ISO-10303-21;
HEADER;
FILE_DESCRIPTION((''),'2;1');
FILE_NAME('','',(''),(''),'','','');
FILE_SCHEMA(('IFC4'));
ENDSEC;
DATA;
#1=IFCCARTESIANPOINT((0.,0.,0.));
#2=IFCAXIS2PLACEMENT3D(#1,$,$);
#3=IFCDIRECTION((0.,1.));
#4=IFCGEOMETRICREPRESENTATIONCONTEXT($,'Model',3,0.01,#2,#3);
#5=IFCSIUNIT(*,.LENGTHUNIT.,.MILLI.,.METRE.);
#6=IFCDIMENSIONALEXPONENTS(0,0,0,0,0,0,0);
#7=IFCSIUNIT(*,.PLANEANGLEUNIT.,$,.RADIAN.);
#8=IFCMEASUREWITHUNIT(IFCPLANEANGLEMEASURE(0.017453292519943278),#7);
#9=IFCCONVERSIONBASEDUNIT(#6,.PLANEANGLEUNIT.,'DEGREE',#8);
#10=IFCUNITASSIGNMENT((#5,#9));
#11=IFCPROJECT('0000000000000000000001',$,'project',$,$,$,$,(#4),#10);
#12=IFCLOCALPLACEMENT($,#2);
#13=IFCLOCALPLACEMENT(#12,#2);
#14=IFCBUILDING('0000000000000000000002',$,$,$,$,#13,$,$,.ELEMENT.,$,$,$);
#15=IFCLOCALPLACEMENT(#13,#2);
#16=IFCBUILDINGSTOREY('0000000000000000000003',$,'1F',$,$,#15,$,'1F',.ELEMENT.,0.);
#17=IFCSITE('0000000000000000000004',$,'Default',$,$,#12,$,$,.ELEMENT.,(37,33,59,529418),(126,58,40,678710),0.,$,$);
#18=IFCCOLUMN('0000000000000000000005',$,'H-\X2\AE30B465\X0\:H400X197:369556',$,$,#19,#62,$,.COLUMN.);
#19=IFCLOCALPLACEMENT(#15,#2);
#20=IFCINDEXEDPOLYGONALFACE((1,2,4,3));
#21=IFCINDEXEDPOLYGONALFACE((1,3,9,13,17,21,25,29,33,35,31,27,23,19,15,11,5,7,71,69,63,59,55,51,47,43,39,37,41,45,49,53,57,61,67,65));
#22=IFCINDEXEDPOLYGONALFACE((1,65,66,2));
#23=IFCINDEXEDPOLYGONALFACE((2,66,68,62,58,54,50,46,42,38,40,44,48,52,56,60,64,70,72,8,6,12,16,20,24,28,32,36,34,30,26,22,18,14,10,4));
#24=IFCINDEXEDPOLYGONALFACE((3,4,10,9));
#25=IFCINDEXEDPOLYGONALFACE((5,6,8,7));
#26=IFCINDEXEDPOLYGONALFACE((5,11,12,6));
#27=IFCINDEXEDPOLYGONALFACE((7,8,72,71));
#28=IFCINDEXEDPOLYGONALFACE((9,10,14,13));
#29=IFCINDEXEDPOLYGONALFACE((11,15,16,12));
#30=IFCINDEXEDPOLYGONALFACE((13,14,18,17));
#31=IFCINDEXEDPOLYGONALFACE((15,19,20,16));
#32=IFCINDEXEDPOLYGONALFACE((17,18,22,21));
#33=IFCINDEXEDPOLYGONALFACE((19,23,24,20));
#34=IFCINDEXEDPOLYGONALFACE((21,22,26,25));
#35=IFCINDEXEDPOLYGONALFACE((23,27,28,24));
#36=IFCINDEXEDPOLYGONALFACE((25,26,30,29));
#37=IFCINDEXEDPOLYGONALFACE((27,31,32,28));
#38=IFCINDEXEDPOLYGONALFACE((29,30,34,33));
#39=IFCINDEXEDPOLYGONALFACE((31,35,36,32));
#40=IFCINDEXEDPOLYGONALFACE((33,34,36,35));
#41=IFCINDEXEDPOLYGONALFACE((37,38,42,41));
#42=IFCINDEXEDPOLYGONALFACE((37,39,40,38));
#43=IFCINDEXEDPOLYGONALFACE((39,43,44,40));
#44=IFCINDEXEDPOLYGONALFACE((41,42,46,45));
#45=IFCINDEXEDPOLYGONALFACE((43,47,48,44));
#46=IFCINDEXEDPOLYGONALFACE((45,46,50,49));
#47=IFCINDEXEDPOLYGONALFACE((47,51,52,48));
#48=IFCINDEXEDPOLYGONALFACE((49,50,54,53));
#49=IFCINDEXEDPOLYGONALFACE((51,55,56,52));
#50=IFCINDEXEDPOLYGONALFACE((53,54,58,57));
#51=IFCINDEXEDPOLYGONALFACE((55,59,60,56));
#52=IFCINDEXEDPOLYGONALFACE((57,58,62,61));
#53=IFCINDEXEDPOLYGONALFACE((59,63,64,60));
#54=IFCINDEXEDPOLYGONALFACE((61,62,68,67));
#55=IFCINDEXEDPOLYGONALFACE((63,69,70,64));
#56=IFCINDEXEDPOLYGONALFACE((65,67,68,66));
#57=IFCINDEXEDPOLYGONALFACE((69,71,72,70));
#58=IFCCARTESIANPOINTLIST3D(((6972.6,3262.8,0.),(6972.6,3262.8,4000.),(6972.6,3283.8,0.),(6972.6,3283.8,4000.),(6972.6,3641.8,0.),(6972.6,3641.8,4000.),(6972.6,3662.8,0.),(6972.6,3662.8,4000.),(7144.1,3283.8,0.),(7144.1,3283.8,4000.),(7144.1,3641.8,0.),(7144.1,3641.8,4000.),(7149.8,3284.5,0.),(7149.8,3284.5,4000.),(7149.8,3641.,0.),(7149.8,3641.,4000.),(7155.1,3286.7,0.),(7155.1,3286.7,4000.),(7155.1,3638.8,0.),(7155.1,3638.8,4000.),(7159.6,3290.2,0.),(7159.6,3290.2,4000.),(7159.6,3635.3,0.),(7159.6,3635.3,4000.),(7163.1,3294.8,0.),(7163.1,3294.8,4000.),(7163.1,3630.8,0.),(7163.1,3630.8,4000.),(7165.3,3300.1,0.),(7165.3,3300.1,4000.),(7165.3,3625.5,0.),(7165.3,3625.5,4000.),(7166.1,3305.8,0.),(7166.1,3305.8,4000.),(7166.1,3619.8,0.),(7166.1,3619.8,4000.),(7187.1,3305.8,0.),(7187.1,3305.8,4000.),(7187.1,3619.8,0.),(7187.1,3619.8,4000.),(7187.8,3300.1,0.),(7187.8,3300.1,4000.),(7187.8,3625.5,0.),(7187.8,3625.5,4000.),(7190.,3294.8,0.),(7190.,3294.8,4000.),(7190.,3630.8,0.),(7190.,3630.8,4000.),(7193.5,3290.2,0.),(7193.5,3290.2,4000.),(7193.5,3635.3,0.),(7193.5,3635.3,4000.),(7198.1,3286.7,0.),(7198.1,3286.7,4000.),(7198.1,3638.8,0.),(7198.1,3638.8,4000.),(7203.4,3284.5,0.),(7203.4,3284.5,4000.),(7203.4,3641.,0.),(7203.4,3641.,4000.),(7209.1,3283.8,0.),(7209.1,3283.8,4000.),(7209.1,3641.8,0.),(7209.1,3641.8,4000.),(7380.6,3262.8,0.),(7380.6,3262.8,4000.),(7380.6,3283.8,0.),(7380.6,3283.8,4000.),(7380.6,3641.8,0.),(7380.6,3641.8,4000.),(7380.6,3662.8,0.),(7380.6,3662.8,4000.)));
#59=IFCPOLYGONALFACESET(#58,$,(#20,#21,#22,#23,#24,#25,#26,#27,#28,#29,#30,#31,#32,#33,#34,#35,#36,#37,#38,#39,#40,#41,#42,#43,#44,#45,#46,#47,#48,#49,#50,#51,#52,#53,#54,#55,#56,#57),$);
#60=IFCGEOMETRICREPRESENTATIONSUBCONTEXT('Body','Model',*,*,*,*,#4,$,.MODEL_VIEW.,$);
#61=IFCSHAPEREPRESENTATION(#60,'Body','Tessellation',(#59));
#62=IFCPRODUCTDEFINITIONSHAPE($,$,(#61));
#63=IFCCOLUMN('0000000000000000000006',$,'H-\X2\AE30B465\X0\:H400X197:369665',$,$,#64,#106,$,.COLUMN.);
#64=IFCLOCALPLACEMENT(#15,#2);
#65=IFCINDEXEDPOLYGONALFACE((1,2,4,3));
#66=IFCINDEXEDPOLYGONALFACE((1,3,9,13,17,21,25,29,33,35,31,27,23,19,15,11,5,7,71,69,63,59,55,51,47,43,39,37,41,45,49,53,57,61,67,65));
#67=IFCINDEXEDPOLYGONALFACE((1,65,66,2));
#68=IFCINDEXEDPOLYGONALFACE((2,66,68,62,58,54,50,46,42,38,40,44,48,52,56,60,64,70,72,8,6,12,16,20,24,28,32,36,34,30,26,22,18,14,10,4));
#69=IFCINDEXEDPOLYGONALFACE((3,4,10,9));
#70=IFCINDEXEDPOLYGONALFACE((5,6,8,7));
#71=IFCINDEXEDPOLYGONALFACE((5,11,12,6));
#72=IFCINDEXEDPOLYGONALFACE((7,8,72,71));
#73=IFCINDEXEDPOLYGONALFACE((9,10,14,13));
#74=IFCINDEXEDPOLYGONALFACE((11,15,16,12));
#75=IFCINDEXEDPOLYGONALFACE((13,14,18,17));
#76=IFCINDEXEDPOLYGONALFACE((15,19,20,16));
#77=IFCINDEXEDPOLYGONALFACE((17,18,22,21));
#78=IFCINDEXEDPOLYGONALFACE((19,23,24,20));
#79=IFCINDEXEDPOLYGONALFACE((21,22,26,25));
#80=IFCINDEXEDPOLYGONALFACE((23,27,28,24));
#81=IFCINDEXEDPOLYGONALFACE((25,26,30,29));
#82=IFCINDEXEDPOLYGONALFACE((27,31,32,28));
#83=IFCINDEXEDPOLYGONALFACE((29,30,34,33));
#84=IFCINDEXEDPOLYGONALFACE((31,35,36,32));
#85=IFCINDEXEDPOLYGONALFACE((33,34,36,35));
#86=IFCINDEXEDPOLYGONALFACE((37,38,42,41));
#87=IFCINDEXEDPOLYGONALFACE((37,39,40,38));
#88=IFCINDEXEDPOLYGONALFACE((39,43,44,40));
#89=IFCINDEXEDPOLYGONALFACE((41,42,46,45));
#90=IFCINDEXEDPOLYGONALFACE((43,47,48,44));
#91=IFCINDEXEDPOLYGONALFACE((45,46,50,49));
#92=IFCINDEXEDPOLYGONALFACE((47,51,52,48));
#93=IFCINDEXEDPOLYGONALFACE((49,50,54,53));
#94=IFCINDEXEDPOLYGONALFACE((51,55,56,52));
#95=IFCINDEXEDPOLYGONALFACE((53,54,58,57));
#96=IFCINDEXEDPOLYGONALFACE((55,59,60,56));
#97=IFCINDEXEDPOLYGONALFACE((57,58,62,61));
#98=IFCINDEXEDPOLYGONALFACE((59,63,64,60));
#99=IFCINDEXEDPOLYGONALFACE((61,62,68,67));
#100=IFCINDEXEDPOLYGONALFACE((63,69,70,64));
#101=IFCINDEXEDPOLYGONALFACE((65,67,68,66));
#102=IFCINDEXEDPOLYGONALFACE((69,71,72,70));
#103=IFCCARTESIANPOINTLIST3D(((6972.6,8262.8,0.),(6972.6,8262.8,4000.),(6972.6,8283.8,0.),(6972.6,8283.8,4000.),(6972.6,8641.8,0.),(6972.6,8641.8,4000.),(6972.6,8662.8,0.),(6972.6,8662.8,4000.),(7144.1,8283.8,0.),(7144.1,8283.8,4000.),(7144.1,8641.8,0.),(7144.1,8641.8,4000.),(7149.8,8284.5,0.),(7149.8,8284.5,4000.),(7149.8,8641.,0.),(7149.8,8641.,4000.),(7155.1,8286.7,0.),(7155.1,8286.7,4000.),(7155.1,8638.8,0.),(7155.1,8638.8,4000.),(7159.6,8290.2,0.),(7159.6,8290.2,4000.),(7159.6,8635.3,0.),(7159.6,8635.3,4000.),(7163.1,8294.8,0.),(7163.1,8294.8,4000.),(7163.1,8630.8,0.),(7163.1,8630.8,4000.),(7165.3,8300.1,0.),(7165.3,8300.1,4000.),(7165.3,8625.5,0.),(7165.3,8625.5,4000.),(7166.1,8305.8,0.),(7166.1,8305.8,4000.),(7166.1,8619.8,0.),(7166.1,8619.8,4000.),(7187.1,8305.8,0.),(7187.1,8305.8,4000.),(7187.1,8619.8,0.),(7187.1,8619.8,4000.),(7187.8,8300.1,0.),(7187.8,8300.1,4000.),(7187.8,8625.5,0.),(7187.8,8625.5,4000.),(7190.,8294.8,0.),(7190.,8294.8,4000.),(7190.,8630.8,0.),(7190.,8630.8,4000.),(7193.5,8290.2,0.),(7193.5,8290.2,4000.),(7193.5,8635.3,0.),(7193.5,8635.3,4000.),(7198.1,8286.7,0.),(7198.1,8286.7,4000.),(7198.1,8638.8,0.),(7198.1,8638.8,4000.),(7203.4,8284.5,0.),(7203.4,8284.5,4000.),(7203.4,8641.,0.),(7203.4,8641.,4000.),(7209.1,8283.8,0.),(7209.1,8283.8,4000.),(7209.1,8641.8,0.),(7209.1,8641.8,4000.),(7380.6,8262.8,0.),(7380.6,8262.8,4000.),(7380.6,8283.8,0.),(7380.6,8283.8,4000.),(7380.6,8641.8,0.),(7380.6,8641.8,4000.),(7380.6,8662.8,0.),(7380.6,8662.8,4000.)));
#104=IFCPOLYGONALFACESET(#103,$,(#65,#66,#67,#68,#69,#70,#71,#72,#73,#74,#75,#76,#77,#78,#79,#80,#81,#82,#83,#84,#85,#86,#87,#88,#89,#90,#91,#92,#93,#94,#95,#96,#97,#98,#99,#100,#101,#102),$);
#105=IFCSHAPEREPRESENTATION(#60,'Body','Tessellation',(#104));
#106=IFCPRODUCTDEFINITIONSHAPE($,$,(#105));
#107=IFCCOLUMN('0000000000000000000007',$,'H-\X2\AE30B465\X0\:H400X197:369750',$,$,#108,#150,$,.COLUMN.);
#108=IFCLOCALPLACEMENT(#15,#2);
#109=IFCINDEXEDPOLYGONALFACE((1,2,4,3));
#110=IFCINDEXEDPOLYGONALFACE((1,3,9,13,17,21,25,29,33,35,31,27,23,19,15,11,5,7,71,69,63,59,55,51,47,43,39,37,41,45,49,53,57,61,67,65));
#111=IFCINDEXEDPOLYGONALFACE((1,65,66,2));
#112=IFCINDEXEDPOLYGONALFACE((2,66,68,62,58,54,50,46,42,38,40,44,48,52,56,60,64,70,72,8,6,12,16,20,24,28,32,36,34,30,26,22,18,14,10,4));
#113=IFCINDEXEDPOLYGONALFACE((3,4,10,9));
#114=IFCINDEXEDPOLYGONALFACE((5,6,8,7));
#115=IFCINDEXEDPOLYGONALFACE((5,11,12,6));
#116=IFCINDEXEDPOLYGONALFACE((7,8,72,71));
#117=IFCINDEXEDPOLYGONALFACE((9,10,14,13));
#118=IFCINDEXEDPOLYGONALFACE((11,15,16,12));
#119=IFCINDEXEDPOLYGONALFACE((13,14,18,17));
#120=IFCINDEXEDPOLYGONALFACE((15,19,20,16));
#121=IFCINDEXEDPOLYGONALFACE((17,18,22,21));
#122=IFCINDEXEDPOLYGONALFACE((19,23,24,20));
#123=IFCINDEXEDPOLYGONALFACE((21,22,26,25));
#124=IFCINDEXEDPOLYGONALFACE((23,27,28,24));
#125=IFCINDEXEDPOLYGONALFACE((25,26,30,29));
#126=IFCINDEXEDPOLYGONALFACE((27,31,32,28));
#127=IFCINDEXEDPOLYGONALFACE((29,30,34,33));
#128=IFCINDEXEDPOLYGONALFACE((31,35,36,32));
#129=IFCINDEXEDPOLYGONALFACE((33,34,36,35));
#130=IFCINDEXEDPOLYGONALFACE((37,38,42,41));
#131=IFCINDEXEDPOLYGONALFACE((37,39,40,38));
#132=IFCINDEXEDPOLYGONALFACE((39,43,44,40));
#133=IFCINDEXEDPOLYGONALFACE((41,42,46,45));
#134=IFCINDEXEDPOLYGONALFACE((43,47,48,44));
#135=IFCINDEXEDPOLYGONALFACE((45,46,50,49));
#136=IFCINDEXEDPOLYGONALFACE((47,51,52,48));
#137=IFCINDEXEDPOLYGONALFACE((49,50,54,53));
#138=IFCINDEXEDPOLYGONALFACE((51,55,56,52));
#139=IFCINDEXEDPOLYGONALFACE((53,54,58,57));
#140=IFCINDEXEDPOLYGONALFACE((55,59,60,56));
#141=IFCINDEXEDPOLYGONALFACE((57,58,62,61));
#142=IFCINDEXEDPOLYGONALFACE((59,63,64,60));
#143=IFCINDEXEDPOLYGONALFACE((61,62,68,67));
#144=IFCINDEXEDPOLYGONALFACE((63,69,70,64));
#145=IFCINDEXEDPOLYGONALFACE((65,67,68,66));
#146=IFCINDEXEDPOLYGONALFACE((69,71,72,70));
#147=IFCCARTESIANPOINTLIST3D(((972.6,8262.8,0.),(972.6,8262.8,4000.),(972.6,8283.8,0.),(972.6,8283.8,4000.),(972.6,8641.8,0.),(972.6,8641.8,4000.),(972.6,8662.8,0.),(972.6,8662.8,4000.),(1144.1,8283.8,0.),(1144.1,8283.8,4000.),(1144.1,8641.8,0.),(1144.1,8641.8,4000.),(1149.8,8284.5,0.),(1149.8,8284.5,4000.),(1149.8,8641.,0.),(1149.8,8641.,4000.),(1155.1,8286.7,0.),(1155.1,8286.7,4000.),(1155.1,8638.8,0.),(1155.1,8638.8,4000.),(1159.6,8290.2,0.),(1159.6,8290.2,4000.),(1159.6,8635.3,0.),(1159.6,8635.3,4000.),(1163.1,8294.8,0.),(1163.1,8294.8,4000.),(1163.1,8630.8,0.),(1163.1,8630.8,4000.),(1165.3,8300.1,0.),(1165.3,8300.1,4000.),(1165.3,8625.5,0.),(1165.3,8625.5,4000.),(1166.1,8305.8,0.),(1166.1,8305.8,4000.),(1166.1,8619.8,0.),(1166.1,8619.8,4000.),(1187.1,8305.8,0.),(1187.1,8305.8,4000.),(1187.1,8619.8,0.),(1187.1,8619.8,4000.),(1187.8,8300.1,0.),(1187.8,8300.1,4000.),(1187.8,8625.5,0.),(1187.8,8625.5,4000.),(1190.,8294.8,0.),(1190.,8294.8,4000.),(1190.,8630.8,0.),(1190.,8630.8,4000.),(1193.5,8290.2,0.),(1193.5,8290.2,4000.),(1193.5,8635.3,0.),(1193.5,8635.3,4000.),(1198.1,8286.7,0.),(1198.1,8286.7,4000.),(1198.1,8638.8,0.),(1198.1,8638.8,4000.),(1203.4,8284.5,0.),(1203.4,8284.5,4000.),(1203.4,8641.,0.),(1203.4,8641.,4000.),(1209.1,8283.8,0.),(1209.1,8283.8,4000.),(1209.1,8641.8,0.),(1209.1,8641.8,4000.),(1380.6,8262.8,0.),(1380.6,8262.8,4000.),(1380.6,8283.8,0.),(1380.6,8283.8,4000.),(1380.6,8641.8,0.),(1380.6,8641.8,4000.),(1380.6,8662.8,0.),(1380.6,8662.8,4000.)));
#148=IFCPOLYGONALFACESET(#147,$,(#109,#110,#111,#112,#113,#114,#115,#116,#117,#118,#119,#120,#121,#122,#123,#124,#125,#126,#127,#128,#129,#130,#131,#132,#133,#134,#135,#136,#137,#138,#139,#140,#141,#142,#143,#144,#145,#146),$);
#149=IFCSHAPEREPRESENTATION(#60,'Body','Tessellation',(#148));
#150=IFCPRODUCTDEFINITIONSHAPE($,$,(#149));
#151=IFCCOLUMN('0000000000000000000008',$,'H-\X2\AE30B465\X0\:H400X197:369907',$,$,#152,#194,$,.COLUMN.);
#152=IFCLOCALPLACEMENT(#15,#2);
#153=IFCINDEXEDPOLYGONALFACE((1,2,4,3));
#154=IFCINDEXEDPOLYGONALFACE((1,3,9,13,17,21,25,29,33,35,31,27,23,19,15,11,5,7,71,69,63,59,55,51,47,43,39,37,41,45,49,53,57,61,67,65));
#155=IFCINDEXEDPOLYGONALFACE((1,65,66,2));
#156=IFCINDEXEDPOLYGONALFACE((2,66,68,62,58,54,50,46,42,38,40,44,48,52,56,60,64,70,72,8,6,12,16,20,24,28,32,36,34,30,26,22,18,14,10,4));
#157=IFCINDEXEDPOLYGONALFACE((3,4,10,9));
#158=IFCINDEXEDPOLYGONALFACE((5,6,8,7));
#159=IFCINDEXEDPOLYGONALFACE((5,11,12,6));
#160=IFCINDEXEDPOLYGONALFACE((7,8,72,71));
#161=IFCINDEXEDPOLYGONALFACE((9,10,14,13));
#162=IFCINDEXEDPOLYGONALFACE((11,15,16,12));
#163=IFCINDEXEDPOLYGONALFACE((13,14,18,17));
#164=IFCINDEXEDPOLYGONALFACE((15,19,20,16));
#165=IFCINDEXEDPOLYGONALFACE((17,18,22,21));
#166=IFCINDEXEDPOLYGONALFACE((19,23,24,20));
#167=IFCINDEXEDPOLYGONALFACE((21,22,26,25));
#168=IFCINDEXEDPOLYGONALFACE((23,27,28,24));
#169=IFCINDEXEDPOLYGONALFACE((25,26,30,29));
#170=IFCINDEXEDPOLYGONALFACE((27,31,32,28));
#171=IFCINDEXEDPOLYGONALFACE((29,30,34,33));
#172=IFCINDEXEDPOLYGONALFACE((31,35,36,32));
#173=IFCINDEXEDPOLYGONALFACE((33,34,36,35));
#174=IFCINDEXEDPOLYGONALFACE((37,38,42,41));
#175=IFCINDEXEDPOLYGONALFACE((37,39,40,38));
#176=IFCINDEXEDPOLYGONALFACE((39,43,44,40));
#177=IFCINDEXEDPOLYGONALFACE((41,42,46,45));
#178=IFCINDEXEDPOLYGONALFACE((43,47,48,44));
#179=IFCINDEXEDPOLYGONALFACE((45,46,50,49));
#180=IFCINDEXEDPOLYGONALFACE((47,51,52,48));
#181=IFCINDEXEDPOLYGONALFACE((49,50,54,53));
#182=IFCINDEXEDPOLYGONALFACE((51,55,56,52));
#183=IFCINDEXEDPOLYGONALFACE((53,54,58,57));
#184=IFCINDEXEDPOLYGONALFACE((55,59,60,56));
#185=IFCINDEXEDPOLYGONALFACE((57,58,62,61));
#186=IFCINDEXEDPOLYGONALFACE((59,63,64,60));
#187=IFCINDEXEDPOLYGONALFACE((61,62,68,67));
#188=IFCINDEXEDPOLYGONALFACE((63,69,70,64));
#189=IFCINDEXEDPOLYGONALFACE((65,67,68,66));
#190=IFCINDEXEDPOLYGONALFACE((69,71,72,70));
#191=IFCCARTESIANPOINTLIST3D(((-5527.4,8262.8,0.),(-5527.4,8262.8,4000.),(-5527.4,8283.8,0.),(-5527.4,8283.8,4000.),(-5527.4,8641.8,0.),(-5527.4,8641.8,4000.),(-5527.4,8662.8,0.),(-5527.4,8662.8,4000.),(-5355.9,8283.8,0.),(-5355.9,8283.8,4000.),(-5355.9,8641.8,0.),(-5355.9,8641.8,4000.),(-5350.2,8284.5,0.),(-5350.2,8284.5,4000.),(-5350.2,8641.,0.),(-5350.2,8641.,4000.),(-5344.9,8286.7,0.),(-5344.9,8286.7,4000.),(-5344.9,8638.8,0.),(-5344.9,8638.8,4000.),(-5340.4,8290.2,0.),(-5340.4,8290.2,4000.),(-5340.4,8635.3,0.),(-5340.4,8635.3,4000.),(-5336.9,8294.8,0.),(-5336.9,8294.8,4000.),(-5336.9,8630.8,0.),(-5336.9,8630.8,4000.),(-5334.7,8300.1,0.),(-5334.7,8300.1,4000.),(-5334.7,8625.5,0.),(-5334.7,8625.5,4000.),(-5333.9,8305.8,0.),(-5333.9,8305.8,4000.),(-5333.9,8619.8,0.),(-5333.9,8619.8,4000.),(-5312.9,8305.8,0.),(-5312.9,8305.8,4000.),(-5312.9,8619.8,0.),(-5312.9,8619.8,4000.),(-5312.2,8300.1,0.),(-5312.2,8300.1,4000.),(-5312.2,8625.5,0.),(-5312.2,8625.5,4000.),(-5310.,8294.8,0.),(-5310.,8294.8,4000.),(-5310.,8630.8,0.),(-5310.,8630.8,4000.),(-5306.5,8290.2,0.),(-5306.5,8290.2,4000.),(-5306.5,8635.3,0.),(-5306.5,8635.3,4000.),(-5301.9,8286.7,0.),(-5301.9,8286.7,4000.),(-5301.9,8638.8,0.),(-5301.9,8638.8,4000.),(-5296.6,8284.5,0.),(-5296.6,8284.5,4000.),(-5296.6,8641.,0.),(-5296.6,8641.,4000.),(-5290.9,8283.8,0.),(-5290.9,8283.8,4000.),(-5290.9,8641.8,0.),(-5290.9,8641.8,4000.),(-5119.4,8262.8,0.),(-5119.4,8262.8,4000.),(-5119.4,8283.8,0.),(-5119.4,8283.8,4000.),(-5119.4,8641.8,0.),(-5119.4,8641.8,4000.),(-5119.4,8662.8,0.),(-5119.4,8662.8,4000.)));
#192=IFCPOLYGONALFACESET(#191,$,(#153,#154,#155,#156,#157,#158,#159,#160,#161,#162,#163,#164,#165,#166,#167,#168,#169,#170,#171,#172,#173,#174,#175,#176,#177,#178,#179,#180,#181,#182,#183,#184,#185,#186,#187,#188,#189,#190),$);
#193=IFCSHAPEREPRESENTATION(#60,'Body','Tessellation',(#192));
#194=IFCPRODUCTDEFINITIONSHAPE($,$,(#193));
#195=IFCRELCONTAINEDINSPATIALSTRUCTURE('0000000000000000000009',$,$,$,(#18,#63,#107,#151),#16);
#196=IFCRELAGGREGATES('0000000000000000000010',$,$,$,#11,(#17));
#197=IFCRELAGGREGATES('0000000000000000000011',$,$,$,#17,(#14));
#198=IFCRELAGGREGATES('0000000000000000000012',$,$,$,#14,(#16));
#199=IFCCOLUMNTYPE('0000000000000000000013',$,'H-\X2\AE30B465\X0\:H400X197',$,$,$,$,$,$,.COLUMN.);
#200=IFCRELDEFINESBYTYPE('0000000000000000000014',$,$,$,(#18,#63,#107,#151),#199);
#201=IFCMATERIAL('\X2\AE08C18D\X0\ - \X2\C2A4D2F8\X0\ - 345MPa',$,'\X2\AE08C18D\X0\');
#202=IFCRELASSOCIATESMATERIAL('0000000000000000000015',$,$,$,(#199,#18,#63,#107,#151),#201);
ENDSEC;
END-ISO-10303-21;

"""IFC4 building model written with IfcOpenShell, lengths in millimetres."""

from ifc_helpers import new_model, entity, si_unit, converted_unit, direction, frame, origin, place, context, subcontext, project, spatial, line, arc, indexed_curve, outline, extrude, source, transform, mapped, material, type_object, type_shapes, element, save


model = new_model("IFC4")

# Units and contexts
model_context = context("Model", 3, precision=0.01, world=origin(), true_north=direction((0.0, 1.0)))
body_context = subcontext(model_context, "Body", "Model", "MODEL_VIEW")
ifc_project = project(units=[si_unit("LENGTHUNIT", "METRE", prefix="MILLI"), converted_unit("PLANEANGLEUNIT", "DEGREE", entity("IfcPlaneAngleMeasure", 0.017453292519943278), si_unit("PLANEANGLEUNIT", "RADIAN"), dimensions=[0, 0, 0, 0, 0, 0, 0])], contexts=[model_context])

# Site, building, storey
site_placement = place(None, origin())
site = spatial("IfcSite", under=ifc_project, at=site_placement, Name="Default", CompositionType="ELEMENT", RefLatitude=(37, 33, 59, 529418), RefLongitude=(126, 58, 40, 678710), RefElevation=0.0)
building_placement = place(site_placement, origin())
building = spatial("IfcBuilding", under=site, at=building_placement, CompositionType="ELEMENT")
storey_placement = place(building_placement, origin())
storey = spatial("IfcBuildingStorey", under=building, at=storey_placement, Name="1F", LongName="1F", CompositionType="ELEMENT", Elevation=0.0)

# Columns
ifc_material = material(Name="금속 - 스틸 - 345MPa", Category="금속")
column_type = type_object("IfcColumnType", Name="H-기둥:H400X197", PredefinedType="COLUMN", material=ifc_material)
shared_shape = source(origin(), body_context, "Body", "SweptSolid", [
    extrude(outline(indexed_curve([(-204.0, -200.0), (204.0, -200.0), (204.0, -179.0), (32.5, -179.0), (16.9, -172.6), (10.5, -157.0), (10.5, 157.0), (16.9, 172.6), (32.5, 179.0), (204.0, 179.0), (204.0, 200.0), (-204.0, 200.0), (-204.0, 179.0), (-32.5, 179.0), (-16.9, 172.6), (-10.5, 157.0), (-10.5, -157.0), (-16.9, -172.6), (-32.5, -179.0), (-204.0, -179.0)], segments=[line(1, 2, 3, 4), arc(4, 5, 6), line(6, 7), arc(7, 8, 9), line(9, 10, 11, 12, 13, 14), arc(14, 15, 16), line(16, 17), arc(17, 18, 19), line(19, 20, 1)], self_intersect=False)), frame((0.0, 0.0, 0.0), z_axis=(0.0, 0.0, 1.0), x_axis=(-1.0, 0.0, 0.0)), (0.0, 0.0, 1.0), 4000.0),
])
type_shapes(column_type, [shared_shape])
for number, where, name in (
    (1, (7176.6, 3462.8, 0.0), "H-기둥:H400X197:369556"),
    (2, (7176.6, 8462.8, 0.0), "H-기둥:H400X197:369665"),
    (3, (1176.6, 8462.8, 0.0), "H-기둥:H400X197:369750"),
    (4, (-5323.4, 8462.8, 0.0), "H-기둥:H400X197:369907"),
):
    element("IfcColumn", number, at=place(storey_placement, frame(where)), inside=storey, type_object=column_type, material=ifc_material, Name=name, PredefinedType="COLUMN", context=body_context, shape_type="MappedRepresentation", body=[
        mapped(shared_shape, transform((0.0, 0.0, 0.0), scale=1.0)),
    ])

save(model, "model.ifc")
